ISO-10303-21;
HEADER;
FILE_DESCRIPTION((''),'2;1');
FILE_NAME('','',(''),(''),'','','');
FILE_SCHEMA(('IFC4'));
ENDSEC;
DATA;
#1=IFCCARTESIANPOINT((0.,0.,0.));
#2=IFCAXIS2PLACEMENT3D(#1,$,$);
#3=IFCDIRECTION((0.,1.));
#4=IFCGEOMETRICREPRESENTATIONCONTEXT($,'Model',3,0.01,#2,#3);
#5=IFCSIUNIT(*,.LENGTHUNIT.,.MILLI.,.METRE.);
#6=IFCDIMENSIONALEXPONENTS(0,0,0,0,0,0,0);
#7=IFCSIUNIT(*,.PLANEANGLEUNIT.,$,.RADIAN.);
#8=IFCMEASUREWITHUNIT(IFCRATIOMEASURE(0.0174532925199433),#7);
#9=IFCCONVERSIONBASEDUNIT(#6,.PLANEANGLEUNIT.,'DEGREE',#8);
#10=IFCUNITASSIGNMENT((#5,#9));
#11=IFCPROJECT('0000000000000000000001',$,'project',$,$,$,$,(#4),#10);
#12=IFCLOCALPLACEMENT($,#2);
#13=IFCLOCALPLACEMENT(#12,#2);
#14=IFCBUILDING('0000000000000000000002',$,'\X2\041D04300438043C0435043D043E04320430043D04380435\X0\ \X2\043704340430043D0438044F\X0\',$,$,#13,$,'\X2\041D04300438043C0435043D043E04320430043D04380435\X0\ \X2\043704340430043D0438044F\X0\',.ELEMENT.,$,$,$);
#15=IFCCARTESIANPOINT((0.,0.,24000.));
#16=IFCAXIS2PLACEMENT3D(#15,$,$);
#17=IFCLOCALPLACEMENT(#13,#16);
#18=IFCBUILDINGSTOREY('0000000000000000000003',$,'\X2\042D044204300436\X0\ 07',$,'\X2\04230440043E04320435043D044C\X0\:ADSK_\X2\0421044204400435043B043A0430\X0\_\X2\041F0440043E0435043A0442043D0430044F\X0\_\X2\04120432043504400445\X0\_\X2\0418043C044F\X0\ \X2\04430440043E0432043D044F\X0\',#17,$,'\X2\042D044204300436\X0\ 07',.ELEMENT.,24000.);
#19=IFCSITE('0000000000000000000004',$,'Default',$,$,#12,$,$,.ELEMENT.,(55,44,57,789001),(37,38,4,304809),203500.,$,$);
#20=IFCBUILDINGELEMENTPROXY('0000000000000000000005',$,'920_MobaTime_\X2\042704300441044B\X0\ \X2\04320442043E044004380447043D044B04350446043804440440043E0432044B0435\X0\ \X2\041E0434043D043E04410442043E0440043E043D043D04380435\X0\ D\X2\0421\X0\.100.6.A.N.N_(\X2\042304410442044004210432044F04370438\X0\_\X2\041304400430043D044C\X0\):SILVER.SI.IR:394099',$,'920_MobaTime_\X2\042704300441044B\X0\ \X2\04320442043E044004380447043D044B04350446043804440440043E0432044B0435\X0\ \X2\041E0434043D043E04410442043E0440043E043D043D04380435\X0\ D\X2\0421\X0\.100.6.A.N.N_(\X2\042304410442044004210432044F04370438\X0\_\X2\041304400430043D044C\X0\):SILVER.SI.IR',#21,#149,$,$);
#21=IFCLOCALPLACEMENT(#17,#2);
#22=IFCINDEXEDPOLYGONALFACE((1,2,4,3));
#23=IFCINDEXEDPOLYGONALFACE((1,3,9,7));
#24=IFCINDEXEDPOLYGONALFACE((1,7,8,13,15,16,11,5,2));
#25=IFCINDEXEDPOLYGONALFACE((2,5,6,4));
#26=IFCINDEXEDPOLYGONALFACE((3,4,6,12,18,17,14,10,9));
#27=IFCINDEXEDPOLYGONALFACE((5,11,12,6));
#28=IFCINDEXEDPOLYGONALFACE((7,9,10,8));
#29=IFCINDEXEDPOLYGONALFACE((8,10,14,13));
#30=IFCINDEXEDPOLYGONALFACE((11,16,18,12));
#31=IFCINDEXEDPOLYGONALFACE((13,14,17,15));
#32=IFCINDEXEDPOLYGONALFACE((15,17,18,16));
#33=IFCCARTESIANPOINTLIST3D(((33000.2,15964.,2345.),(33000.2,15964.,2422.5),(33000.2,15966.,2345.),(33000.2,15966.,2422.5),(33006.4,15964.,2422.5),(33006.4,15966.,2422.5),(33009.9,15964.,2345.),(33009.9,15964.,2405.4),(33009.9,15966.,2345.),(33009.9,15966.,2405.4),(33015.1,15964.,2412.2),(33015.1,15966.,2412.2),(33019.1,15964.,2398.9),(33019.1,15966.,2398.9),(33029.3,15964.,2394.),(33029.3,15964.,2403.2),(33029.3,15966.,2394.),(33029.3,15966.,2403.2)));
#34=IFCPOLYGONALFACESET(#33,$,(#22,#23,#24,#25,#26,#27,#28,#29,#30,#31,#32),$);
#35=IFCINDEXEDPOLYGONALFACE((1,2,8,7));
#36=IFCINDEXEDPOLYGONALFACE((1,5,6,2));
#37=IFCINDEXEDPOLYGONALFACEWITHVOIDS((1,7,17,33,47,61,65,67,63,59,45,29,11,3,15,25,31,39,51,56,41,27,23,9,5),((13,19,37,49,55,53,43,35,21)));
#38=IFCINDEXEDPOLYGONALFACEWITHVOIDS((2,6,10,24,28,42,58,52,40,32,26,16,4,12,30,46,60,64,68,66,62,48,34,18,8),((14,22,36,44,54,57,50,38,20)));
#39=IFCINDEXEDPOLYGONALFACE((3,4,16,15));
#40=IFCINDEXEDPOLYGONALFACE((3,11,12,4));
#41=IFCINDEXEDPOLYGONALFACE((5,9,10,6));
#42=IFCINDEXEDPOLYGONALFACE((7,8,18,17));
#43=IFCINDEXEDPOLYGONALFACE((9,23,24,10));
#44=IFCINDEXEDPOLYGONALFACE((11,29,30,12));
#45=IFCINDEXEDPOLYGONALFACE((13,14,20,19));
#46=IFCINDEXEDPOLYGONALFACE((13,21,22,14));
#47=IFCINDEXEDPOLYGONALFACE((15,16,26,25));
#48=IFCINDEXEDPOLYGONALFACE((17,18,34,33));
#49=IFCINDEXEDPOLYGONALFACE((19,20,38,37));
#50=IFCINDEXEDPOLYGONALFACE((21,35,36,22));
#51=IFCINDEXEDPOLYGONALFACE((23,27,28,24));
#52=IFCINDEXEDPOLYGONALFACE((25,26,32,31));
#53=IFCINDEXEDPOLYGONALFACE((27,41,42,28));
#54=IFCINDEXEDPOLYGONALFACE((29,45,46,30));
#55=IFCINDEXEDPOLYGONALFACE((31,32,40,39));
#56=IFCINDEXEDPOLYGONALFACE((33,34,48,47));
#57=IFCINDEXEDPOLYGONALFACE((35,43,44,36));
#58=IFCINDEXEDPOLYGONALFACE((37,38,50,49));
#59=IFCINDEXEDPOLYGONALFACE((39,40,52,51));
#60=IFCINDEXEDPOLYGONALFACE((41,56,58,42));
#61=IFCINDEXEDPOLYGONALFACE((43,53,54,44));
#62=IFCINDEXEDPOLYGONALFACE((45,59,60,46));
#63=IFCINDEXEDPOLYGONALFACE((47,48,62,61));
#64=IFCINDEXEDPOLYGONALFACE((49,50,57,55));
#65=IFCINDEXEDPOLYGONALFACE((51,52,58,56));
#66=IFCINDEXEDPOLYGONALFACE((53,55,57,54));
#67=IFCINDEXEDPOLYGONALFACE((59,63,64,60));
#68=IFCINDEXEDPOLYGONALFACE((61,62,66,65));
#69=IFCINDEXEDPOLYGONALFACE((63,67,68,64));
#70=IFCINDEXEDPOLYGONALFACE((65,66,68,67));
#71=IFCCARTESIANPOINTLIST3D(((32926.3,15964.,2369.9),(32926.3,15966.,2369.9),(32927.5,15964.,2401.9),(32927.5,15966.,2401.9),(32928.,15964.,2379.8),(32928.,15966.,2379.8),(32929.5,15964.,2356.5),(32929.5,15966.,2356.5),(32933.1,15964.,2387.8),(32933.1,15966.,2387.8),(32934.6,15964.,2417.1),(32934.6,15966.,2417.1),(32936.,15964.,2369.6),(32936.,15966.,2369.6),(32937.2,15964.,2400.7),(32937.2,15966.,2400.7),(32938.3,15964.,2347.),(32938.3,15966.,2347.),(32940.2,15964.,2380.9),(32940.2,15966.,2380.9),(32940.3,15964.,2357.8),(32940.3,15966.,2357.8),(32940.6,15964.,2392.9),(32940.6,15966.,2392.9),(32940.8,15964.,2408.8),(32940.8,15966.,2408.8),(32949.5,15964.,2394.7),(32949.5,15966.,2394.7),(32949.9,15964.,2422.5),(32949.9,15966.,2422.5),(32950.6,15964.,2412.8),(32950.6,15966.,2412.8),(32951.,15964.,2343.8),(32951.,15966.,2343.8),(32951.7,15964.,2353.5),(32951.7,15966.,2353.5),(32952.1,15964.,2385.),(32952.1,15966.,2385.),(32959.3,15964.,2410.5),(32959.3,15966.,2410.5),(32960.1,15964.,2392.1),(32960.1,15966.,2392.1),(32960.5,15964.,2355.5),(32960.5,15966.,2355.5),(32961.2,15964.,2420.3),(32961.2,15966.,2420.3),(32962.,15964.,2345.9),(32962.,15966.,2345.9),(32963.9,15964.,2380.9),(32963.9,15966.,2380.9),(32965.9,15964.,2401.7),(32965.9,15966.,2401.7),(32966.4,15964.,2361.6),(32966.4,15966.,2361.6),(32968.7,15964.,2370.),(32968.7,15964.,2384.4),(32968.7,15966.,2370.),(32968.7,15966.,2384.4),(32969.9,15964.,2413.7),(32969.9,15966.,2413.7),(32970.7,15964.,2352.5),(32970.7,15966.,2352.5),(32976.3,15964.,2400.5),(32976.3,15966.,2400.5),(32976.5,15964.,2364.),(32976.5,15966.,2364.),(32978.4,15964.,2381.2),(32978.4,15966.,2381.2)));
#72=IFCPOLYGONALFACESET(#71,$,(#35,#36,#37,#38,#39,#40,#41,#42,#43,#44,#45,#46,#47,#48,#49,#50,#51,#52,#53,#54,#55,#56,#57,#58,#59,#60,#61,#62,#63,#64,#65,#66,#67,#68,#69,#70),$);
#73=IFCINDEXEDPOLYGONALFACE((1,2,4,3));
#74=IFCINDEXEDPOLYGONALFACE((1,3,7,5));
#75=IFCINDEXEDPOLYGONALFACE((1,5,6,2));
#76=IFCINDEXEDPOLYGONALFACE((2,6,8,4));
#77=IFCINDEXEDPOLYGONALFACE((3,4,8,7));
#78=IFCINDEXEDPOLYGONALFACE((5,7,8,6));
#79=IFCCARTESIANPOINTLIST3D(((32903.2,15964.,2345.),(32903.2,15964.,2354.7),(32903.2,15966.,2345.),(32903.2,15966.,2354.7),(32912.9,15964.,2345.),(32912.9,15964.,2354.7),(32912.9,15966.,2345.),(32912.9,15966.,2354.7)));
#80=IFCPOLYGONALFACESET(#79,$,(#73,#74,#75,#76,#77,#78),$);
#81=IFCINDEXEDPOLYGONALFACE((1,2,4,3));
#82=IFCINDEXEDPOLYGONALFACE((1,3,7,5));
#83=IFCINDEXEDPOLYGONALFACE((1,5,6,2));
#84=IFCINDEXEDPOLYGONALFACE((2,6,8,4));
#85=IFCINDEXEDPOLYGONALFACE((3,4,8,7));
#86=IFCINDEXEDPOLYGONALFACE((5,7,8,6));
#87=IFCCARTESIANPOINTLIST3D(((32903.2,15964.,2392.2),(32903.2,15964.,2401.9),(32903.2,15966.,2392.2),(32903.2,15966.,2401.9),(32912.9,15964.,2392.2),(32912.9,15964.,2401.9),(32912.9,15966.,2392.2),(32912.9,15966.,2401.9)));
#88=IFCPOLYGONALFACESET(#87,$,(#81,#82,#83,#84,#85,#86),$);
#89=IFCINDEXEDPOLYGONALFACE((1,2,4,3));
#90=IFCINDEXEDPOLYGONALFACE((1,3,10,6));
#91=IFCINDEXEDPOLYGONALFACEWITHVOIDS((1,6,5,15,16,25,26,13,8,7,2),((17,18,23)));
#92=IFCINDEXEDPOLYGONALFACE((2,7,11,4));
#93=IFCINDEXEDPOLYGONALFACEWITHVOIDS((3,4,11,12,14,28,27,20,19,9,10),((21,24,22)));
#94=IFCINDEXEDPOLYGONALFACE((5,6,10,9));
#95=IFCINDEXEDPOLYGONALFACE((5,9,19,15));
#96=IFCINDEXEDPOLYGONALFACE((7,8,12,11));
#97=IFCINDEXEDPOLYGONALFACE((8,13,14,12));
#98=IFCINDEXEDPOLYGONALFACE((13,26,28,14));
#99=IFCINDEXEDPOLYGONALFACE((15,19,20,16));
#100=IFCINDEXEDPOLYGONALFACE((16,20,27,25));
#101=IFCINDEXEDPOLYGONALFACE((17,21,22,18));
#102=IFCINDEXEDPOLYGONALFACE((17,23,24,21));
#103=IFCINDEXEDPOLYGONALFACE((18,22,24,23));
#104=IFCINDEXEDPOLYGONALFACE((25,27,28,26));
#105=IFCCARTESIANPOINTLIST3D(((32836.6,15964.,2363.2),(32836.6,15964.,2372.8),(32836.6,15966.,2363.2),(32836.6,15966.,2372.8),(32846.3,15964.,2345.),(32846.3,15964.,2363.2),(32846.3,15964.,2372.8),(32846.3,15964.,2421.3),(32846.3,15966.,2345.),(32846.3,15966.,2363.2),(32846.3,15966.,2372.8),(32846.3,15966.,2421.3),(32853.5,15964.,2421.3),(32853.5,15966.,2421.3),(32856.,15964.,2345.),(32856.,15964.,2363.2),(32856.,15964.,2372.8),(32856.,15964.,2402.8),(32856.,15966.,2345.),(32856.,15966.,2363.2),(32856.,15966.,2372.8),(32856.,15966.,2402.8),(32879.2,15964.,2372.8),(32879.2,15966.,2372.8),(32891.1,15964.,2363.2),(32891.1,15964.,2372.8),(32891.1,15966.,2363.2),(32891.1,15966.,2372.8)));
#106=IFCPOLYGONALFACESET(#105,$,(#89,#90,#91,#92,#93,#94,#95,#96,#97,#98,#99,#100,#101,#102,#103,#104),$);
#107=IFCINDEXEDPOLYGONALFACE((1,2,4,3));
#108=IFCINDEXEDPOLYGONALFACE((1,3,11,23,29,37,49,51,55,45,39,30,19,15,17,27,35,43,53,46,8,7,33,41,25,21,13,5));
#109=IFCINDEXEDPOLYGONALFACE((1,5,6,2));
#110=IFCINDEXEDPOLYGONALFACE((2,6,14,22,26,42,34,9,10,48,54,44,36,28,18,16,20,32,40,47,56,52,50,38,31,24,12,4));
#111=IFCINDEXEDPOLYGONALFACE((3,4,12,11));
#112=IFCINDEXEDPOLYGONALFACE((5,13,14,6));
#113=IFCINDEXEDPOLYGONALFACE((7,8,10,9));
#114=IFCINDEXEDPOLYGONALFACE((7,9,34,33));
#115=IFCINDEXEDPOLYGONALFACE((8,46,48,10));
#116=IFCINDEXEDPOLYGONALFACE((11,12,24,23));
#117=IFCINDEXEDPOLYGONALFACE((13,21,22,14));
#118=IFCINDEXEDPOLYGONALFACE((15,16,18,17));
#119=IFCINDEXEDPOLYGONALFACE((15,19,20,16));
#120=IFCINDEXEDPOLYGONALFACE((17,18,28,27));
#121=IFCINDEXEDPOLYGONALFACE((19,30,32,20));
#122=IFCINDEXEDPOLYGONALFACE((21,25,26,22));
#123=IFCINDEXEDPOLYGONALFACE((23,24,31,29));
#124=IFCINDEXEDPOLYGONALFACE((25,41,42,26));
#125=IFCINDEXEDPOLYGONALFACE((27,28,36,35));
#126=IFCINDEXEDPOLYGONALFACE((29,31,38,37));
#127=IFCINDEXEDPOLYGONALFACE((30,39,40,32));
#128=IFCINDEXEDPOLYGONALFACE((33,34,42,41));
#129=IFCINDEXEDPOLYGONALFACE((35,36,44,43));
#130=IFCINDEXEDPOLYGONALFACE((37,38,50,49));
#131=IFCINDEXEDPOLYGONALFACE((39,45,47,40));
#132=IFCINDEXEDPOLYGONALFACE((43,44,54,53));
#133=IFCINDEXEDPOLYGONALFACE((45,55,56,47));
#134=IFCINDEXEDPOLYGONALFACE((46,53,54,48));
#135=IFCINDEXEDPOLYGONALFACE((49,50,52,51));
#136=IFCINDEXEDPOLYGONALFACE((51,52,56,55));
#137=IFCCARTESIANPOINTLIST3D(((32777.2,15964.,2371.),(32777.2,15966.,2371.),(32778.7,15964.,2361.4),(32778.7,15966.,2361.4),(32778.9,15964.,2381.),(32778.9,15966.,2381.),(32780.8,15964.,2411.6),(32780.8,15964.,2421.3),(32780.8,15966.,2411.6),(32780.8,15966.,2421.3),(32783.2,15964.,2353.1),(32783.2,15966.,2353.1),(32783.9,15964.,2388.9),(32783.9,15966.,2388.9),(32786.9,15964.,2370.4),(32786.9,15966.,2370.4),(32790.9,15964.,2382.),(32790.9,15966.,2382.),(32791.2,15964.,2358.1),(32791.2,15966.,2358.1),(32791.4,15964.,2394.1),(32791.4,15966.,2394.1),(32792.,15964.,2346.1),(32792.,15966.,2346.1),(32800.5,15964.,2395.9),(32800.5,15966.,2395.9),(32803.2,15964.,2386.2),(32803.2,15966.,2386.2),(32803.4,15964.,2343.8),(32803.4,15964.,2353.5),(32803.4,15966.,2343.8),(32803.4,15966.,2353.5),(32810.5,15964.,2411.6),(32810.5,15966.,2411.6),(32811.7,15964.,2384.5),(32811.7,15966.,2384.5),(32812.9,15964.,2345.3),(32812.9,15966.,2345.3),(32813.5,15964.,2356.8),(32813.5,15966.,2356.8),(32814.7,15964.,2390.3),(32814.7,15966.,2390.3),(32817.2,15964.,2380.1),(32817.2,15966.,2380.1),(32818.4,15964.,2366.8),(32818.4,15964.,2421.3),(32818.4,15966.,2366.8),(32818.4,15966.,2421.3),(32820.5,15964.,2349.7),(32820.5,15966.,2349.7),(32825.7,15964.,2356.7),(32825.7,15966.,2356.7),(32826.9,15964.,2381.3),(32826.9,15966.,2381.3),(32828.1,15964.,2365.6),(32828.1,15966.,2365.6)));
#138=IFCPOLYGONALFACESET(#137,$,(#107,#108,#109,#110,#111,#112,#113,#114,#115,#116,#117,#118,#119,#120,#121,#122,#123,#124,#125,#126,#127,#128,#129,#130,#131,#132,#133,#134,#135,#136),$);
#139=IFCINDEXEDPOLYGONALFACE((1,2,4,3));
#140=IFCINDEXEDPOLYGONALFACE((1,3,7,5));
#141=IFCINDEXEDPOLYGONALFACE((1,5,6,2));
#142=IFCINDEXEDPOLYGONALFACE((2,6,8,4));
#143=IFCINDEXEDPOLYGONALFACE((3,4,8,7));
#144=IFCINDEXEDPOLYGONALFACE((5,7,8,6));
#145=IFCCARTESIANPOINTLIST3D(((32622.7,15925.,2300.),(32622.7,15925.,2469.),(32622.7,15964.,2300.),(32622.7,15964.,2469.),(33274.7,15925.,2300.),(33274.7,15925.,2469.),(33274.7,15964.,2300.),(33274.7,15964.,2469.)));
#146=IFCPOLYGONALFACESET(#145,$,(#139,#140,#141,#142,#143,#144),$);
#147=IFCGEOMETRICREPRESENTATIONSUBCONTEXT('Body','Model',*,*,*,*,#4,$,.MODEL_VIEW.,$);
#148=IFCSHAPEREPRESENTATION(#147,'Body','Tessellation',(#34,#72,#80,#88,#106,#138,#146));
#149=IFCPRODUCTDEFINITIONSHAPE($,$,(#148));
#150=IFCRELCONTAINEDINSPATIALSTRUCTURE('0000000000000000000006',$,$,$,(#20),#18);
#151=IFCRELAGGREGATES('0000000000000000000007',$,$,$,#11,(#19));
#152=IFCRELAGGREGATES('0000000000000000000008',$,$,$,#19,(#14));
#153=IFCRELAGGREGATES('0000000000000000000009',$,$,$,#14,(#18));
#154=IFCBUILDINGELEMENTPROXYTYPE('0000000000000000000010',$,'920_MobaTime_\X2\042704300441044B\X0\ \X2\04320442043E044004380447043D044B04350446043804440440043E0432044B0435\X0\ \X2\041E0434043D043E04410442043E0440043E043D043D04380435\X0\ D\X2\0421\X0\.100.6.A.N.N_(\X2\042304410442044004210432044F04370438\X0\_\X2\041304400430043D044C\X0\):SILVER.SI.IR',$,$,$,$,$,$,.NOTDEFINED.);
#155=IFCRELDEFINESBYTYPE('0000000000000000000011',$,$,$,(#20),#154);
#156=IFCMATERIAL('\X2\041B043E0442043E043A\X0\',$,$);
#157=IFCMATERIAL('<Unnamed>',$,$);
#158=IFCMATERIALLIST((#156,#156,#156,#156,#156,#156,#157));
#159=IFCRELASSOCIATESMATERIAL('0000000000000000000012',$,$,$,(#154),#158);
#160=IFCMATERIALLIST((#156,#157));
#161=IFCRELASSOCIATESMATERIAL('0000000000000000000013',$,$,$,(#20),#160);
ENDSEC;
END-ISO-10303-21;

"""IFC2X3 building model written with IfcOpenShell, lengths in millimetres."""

from ifc_helpers import new_model, entity, si_unit, converted_unit, direction, frame, origin, origin_2d_with_axis, place, context, subcontext, project, spatial, polyline, rectangle, outline, extrude, source, transform, mapped, material, material_list, type_object, type_shapes, element, save


model = new_model("IFC2X3")

# Units and contexts
model_context = context("Model", 3, precision=0.01, world=origin(), true_north=direction((0.0, 1.0)))
body_context = subcontext(model_context, "Body", "Model", "MODEL_VIEW")
ifc_project = project(units=[si_unit("LENGTHUNIT", "METRE", prefix="MILLI"), converted_unit("PLANEANGLEUNIT", "DEGREE", entity("IfcRatioMeasure", 0.0174532925199433), si_unit("PLANEANGLEUNIT", "RADIAN"), dimensions=[0, 0, 0, 0, 0, 0, 0])], contexts=[model_context])

# Site, building, storey
site_placement = place(None, frame((0.0, 0.0, 0.0)))
site = spatial("IfcSite", under=ifc_project, at=site_placement, Name="Default", CompositionType="ELEMENT", RefLatitude=(55, 44, 57, 789001), RefLongitude=(37, 38, 4, 304809), RefElevation=203500.0)
building_placement = place(site_placement, origin())
building = spatial("IfcBuilding", under=site, at=building_placement, Name="Наименование здания", LongName="Наименование здания", CompositionType="ELEMENT")
storey_placement = place(building_placement, frame((0.0, 0.0, 24000.0)))
storey = spatial("IfcBuildingStorey", under=building, at=storey_placement, Name="Этаж 07", ObjectType="Уровень:ADSK_Стрелка_Проектная_Вверх_Имя уровня", LongName="Этаж 07", CompositionType="ELEMENT", Elevation=24000.0)

# Building element proxy
ifc_material_1 = material(Name="Лоток")
ifc_material_2 = material(Name="<Unnamed>")
ifc_material_list_1 = material_list([ifc_material_1, ifc_material_1, ifc_material_1, ifc_material_1, ifc_material_1, ifc_material_1, ifc_material_2])
building_element_proxy_type = type_object("IfcBuildingElementProxyType", Name="920_MobaTime_Часы вторичныецифровые Односторонние DС.100.6.A.N.N_(УстрСвязи_Грань):SILVER.SI.IR", PredefinedType="NOTDEFINED", material=ifc_material_list_1)
shared_shape = source(origin(), body_context, "Body", "SweptSolid", [
    extrude(outline(polyline([(-49.3, -13.1), (28.2, -13.1), (28.2, -6.8), (17.9, 1.8), (8.9, 16.0), (-0.3, 16.0), (4.6, 5.8), (11.1, -3.4), (-49.3, -3.4), (-49.3, -13.1)])), frame((-64.6, 9.8, 39.0), z_axis=(0.0, 0.0, 1.0), x_axis=(0.0, 1.0, 0.0)), (0.0, 0.0, 1.0), 2.0),
    extrude(outline(polyline([(2.2, -27.6), (19.0, -27.6), (30.5, -16.1), (33.3, -4.9), (31.0, 5.8), (21.8, 17.2), (5.2, 27.3), (-11.1, 33.0), (-24.0, 32.7), (-33.6, 27.6), (-40.3, 18.6), (-42.8, 5.7), (-38.0, -6.3), (-27.2, -15.0), (-17.5, -17.7), (-8.2, -16.4), (-0.3, -11.9), (5.1, -4.5), (7.3, 6.2), (4.0, 17.2), (18.5, 7.3), (23.6, -2.4), (22.0, -11.4), (14.2, -18.4), (5.3, -18.3), (2.2, -27.6)]), holes=[polyline([(-9.0, 23.3), (-1.3, 14.4), (-2.6, 2.0), (-11.4, -7.0), (-23.4, -6.1), (-32.2, 2.9), (-31.2, 15.1), (-25.6, 22.1), (-17.5, 24.9), (-9.0, 23.3)])]), frame((-2.7, 3.6, 39.0), z_axis=(0.0, 0.0, 1.0), x_axis=(-0.427649, 0.903945, 0.0)), (0.0, 0.0, 1.0), 2.0),
    extrude(rectangle(XDim=9.7, YDim=9.7, at=origin_2d_with_axis()), frame((40.6, -34.7, 39.0)), (0.0, 0.0, 1.0), 2.0),
    extrude(rectangle(XDim=9.7, YDim=9.7, at=origin_2d_with_axis()), frame((40.6, 12.6, 39.0)), (0.0, 0.0, 1.0), 2.0),
    extrude(outline(polyline([(-0.9, -28.1), (8.8, -28.1), (8.8, -9.9), (18.5, -9.9), (18.5, -0.2), (8.8, -0.2), (8.8, 48.3), (1.5, 48.3), (-36.0, -0.2), (-36.0, -9.9), (-0.9, -9.9), (-0.9, -28.1)]), holes=[polyline([(-0.9, -0.2), (-24.1, -0.2), (-0.9, 29.7), (-0.9, -0.2)])]), frame((93.6, -11.4, 39.0)), (0.0, 0.0, 1.0), 2.0),
    extrude(outline(polyline([(3.3, -28.3), (12.5, -28.3), (20.5, -25.0), (26.8, -18.8), (30.7, -10.0), (31.4, 1.6), (26.9, 11.8), (20.1, 18.4), (11.1, 22.3), (1.0, 23.3), (-7.9, 20.4), (-14.9, 14.5), (-18.9, 6.2), (-17.1, -9.0), (-36.7, 0.5), (-29.1, 29.3), (-38.5, 31.7), (-48.1, -4.6), (-11.6, -23.0), (-8.0, -14.0), (-10.8, -7.6), (-10.2, 1.1), (-3.0, 11.8), (9.2, 12.8), (20.0, 5.4), (21.3, -7.5), (15.5, -16.4), (4.6, -18.6), (3.3, -28.3)])), frame((147.1, -8.5, 39.0), z_axis=(0.0, 0.0, 1.0), x_axis=(0.256974, -0.966418, 0.0)), (0.0, 0.0, 1.0), 2.0),
    extrude(rectangle(XDim=652.0, YDim=169.0, at=origin_2d_with_axis()), frame((0.0, 0.0, 0.0), z_axis=(0.0, 0.0, 1.0), x_axis=(-1.0, 0.0, 0.0)), (0.0, 0.0, 1.0), 39.0),
])
type_shapes(building_element_proxy_type, [shared_shape])
ifc_material_list_2 = material_list([ifc_material_1, ifc_material_2])
proxy_1_placement = place(storey_placement, frame((32948.7, 15925.0, 2384.5), z_axis=(0.0, 1.0, 0.0), x_axis=(-1.0, 0.0, 0.0)))
element("IfcBuildingElementProxy", 1, at=proxy_1_placement, inside=storey, type_object=building_element_proxy_type, material=ifc_material_list_2, Name="920_MobaTime_Часы вторичныецифровые Односторонние DС.100.6.A.N.N_(УстрСвязи_Грань):SILVER.SI.IR:394099", ObjectType="920_MobaTime_Часы вторичныецифровые Односторонние DС.100.6.A.N.N_(УстрСвязи_Грань):SILVER.SI.IR", context=body_context, shape_type="MappedRepresentation", body=[
    mapped(shared_shape, transform((0.0, 0.0, 0.0), scale=1.0)),
])

save(model, "model.ifc")
